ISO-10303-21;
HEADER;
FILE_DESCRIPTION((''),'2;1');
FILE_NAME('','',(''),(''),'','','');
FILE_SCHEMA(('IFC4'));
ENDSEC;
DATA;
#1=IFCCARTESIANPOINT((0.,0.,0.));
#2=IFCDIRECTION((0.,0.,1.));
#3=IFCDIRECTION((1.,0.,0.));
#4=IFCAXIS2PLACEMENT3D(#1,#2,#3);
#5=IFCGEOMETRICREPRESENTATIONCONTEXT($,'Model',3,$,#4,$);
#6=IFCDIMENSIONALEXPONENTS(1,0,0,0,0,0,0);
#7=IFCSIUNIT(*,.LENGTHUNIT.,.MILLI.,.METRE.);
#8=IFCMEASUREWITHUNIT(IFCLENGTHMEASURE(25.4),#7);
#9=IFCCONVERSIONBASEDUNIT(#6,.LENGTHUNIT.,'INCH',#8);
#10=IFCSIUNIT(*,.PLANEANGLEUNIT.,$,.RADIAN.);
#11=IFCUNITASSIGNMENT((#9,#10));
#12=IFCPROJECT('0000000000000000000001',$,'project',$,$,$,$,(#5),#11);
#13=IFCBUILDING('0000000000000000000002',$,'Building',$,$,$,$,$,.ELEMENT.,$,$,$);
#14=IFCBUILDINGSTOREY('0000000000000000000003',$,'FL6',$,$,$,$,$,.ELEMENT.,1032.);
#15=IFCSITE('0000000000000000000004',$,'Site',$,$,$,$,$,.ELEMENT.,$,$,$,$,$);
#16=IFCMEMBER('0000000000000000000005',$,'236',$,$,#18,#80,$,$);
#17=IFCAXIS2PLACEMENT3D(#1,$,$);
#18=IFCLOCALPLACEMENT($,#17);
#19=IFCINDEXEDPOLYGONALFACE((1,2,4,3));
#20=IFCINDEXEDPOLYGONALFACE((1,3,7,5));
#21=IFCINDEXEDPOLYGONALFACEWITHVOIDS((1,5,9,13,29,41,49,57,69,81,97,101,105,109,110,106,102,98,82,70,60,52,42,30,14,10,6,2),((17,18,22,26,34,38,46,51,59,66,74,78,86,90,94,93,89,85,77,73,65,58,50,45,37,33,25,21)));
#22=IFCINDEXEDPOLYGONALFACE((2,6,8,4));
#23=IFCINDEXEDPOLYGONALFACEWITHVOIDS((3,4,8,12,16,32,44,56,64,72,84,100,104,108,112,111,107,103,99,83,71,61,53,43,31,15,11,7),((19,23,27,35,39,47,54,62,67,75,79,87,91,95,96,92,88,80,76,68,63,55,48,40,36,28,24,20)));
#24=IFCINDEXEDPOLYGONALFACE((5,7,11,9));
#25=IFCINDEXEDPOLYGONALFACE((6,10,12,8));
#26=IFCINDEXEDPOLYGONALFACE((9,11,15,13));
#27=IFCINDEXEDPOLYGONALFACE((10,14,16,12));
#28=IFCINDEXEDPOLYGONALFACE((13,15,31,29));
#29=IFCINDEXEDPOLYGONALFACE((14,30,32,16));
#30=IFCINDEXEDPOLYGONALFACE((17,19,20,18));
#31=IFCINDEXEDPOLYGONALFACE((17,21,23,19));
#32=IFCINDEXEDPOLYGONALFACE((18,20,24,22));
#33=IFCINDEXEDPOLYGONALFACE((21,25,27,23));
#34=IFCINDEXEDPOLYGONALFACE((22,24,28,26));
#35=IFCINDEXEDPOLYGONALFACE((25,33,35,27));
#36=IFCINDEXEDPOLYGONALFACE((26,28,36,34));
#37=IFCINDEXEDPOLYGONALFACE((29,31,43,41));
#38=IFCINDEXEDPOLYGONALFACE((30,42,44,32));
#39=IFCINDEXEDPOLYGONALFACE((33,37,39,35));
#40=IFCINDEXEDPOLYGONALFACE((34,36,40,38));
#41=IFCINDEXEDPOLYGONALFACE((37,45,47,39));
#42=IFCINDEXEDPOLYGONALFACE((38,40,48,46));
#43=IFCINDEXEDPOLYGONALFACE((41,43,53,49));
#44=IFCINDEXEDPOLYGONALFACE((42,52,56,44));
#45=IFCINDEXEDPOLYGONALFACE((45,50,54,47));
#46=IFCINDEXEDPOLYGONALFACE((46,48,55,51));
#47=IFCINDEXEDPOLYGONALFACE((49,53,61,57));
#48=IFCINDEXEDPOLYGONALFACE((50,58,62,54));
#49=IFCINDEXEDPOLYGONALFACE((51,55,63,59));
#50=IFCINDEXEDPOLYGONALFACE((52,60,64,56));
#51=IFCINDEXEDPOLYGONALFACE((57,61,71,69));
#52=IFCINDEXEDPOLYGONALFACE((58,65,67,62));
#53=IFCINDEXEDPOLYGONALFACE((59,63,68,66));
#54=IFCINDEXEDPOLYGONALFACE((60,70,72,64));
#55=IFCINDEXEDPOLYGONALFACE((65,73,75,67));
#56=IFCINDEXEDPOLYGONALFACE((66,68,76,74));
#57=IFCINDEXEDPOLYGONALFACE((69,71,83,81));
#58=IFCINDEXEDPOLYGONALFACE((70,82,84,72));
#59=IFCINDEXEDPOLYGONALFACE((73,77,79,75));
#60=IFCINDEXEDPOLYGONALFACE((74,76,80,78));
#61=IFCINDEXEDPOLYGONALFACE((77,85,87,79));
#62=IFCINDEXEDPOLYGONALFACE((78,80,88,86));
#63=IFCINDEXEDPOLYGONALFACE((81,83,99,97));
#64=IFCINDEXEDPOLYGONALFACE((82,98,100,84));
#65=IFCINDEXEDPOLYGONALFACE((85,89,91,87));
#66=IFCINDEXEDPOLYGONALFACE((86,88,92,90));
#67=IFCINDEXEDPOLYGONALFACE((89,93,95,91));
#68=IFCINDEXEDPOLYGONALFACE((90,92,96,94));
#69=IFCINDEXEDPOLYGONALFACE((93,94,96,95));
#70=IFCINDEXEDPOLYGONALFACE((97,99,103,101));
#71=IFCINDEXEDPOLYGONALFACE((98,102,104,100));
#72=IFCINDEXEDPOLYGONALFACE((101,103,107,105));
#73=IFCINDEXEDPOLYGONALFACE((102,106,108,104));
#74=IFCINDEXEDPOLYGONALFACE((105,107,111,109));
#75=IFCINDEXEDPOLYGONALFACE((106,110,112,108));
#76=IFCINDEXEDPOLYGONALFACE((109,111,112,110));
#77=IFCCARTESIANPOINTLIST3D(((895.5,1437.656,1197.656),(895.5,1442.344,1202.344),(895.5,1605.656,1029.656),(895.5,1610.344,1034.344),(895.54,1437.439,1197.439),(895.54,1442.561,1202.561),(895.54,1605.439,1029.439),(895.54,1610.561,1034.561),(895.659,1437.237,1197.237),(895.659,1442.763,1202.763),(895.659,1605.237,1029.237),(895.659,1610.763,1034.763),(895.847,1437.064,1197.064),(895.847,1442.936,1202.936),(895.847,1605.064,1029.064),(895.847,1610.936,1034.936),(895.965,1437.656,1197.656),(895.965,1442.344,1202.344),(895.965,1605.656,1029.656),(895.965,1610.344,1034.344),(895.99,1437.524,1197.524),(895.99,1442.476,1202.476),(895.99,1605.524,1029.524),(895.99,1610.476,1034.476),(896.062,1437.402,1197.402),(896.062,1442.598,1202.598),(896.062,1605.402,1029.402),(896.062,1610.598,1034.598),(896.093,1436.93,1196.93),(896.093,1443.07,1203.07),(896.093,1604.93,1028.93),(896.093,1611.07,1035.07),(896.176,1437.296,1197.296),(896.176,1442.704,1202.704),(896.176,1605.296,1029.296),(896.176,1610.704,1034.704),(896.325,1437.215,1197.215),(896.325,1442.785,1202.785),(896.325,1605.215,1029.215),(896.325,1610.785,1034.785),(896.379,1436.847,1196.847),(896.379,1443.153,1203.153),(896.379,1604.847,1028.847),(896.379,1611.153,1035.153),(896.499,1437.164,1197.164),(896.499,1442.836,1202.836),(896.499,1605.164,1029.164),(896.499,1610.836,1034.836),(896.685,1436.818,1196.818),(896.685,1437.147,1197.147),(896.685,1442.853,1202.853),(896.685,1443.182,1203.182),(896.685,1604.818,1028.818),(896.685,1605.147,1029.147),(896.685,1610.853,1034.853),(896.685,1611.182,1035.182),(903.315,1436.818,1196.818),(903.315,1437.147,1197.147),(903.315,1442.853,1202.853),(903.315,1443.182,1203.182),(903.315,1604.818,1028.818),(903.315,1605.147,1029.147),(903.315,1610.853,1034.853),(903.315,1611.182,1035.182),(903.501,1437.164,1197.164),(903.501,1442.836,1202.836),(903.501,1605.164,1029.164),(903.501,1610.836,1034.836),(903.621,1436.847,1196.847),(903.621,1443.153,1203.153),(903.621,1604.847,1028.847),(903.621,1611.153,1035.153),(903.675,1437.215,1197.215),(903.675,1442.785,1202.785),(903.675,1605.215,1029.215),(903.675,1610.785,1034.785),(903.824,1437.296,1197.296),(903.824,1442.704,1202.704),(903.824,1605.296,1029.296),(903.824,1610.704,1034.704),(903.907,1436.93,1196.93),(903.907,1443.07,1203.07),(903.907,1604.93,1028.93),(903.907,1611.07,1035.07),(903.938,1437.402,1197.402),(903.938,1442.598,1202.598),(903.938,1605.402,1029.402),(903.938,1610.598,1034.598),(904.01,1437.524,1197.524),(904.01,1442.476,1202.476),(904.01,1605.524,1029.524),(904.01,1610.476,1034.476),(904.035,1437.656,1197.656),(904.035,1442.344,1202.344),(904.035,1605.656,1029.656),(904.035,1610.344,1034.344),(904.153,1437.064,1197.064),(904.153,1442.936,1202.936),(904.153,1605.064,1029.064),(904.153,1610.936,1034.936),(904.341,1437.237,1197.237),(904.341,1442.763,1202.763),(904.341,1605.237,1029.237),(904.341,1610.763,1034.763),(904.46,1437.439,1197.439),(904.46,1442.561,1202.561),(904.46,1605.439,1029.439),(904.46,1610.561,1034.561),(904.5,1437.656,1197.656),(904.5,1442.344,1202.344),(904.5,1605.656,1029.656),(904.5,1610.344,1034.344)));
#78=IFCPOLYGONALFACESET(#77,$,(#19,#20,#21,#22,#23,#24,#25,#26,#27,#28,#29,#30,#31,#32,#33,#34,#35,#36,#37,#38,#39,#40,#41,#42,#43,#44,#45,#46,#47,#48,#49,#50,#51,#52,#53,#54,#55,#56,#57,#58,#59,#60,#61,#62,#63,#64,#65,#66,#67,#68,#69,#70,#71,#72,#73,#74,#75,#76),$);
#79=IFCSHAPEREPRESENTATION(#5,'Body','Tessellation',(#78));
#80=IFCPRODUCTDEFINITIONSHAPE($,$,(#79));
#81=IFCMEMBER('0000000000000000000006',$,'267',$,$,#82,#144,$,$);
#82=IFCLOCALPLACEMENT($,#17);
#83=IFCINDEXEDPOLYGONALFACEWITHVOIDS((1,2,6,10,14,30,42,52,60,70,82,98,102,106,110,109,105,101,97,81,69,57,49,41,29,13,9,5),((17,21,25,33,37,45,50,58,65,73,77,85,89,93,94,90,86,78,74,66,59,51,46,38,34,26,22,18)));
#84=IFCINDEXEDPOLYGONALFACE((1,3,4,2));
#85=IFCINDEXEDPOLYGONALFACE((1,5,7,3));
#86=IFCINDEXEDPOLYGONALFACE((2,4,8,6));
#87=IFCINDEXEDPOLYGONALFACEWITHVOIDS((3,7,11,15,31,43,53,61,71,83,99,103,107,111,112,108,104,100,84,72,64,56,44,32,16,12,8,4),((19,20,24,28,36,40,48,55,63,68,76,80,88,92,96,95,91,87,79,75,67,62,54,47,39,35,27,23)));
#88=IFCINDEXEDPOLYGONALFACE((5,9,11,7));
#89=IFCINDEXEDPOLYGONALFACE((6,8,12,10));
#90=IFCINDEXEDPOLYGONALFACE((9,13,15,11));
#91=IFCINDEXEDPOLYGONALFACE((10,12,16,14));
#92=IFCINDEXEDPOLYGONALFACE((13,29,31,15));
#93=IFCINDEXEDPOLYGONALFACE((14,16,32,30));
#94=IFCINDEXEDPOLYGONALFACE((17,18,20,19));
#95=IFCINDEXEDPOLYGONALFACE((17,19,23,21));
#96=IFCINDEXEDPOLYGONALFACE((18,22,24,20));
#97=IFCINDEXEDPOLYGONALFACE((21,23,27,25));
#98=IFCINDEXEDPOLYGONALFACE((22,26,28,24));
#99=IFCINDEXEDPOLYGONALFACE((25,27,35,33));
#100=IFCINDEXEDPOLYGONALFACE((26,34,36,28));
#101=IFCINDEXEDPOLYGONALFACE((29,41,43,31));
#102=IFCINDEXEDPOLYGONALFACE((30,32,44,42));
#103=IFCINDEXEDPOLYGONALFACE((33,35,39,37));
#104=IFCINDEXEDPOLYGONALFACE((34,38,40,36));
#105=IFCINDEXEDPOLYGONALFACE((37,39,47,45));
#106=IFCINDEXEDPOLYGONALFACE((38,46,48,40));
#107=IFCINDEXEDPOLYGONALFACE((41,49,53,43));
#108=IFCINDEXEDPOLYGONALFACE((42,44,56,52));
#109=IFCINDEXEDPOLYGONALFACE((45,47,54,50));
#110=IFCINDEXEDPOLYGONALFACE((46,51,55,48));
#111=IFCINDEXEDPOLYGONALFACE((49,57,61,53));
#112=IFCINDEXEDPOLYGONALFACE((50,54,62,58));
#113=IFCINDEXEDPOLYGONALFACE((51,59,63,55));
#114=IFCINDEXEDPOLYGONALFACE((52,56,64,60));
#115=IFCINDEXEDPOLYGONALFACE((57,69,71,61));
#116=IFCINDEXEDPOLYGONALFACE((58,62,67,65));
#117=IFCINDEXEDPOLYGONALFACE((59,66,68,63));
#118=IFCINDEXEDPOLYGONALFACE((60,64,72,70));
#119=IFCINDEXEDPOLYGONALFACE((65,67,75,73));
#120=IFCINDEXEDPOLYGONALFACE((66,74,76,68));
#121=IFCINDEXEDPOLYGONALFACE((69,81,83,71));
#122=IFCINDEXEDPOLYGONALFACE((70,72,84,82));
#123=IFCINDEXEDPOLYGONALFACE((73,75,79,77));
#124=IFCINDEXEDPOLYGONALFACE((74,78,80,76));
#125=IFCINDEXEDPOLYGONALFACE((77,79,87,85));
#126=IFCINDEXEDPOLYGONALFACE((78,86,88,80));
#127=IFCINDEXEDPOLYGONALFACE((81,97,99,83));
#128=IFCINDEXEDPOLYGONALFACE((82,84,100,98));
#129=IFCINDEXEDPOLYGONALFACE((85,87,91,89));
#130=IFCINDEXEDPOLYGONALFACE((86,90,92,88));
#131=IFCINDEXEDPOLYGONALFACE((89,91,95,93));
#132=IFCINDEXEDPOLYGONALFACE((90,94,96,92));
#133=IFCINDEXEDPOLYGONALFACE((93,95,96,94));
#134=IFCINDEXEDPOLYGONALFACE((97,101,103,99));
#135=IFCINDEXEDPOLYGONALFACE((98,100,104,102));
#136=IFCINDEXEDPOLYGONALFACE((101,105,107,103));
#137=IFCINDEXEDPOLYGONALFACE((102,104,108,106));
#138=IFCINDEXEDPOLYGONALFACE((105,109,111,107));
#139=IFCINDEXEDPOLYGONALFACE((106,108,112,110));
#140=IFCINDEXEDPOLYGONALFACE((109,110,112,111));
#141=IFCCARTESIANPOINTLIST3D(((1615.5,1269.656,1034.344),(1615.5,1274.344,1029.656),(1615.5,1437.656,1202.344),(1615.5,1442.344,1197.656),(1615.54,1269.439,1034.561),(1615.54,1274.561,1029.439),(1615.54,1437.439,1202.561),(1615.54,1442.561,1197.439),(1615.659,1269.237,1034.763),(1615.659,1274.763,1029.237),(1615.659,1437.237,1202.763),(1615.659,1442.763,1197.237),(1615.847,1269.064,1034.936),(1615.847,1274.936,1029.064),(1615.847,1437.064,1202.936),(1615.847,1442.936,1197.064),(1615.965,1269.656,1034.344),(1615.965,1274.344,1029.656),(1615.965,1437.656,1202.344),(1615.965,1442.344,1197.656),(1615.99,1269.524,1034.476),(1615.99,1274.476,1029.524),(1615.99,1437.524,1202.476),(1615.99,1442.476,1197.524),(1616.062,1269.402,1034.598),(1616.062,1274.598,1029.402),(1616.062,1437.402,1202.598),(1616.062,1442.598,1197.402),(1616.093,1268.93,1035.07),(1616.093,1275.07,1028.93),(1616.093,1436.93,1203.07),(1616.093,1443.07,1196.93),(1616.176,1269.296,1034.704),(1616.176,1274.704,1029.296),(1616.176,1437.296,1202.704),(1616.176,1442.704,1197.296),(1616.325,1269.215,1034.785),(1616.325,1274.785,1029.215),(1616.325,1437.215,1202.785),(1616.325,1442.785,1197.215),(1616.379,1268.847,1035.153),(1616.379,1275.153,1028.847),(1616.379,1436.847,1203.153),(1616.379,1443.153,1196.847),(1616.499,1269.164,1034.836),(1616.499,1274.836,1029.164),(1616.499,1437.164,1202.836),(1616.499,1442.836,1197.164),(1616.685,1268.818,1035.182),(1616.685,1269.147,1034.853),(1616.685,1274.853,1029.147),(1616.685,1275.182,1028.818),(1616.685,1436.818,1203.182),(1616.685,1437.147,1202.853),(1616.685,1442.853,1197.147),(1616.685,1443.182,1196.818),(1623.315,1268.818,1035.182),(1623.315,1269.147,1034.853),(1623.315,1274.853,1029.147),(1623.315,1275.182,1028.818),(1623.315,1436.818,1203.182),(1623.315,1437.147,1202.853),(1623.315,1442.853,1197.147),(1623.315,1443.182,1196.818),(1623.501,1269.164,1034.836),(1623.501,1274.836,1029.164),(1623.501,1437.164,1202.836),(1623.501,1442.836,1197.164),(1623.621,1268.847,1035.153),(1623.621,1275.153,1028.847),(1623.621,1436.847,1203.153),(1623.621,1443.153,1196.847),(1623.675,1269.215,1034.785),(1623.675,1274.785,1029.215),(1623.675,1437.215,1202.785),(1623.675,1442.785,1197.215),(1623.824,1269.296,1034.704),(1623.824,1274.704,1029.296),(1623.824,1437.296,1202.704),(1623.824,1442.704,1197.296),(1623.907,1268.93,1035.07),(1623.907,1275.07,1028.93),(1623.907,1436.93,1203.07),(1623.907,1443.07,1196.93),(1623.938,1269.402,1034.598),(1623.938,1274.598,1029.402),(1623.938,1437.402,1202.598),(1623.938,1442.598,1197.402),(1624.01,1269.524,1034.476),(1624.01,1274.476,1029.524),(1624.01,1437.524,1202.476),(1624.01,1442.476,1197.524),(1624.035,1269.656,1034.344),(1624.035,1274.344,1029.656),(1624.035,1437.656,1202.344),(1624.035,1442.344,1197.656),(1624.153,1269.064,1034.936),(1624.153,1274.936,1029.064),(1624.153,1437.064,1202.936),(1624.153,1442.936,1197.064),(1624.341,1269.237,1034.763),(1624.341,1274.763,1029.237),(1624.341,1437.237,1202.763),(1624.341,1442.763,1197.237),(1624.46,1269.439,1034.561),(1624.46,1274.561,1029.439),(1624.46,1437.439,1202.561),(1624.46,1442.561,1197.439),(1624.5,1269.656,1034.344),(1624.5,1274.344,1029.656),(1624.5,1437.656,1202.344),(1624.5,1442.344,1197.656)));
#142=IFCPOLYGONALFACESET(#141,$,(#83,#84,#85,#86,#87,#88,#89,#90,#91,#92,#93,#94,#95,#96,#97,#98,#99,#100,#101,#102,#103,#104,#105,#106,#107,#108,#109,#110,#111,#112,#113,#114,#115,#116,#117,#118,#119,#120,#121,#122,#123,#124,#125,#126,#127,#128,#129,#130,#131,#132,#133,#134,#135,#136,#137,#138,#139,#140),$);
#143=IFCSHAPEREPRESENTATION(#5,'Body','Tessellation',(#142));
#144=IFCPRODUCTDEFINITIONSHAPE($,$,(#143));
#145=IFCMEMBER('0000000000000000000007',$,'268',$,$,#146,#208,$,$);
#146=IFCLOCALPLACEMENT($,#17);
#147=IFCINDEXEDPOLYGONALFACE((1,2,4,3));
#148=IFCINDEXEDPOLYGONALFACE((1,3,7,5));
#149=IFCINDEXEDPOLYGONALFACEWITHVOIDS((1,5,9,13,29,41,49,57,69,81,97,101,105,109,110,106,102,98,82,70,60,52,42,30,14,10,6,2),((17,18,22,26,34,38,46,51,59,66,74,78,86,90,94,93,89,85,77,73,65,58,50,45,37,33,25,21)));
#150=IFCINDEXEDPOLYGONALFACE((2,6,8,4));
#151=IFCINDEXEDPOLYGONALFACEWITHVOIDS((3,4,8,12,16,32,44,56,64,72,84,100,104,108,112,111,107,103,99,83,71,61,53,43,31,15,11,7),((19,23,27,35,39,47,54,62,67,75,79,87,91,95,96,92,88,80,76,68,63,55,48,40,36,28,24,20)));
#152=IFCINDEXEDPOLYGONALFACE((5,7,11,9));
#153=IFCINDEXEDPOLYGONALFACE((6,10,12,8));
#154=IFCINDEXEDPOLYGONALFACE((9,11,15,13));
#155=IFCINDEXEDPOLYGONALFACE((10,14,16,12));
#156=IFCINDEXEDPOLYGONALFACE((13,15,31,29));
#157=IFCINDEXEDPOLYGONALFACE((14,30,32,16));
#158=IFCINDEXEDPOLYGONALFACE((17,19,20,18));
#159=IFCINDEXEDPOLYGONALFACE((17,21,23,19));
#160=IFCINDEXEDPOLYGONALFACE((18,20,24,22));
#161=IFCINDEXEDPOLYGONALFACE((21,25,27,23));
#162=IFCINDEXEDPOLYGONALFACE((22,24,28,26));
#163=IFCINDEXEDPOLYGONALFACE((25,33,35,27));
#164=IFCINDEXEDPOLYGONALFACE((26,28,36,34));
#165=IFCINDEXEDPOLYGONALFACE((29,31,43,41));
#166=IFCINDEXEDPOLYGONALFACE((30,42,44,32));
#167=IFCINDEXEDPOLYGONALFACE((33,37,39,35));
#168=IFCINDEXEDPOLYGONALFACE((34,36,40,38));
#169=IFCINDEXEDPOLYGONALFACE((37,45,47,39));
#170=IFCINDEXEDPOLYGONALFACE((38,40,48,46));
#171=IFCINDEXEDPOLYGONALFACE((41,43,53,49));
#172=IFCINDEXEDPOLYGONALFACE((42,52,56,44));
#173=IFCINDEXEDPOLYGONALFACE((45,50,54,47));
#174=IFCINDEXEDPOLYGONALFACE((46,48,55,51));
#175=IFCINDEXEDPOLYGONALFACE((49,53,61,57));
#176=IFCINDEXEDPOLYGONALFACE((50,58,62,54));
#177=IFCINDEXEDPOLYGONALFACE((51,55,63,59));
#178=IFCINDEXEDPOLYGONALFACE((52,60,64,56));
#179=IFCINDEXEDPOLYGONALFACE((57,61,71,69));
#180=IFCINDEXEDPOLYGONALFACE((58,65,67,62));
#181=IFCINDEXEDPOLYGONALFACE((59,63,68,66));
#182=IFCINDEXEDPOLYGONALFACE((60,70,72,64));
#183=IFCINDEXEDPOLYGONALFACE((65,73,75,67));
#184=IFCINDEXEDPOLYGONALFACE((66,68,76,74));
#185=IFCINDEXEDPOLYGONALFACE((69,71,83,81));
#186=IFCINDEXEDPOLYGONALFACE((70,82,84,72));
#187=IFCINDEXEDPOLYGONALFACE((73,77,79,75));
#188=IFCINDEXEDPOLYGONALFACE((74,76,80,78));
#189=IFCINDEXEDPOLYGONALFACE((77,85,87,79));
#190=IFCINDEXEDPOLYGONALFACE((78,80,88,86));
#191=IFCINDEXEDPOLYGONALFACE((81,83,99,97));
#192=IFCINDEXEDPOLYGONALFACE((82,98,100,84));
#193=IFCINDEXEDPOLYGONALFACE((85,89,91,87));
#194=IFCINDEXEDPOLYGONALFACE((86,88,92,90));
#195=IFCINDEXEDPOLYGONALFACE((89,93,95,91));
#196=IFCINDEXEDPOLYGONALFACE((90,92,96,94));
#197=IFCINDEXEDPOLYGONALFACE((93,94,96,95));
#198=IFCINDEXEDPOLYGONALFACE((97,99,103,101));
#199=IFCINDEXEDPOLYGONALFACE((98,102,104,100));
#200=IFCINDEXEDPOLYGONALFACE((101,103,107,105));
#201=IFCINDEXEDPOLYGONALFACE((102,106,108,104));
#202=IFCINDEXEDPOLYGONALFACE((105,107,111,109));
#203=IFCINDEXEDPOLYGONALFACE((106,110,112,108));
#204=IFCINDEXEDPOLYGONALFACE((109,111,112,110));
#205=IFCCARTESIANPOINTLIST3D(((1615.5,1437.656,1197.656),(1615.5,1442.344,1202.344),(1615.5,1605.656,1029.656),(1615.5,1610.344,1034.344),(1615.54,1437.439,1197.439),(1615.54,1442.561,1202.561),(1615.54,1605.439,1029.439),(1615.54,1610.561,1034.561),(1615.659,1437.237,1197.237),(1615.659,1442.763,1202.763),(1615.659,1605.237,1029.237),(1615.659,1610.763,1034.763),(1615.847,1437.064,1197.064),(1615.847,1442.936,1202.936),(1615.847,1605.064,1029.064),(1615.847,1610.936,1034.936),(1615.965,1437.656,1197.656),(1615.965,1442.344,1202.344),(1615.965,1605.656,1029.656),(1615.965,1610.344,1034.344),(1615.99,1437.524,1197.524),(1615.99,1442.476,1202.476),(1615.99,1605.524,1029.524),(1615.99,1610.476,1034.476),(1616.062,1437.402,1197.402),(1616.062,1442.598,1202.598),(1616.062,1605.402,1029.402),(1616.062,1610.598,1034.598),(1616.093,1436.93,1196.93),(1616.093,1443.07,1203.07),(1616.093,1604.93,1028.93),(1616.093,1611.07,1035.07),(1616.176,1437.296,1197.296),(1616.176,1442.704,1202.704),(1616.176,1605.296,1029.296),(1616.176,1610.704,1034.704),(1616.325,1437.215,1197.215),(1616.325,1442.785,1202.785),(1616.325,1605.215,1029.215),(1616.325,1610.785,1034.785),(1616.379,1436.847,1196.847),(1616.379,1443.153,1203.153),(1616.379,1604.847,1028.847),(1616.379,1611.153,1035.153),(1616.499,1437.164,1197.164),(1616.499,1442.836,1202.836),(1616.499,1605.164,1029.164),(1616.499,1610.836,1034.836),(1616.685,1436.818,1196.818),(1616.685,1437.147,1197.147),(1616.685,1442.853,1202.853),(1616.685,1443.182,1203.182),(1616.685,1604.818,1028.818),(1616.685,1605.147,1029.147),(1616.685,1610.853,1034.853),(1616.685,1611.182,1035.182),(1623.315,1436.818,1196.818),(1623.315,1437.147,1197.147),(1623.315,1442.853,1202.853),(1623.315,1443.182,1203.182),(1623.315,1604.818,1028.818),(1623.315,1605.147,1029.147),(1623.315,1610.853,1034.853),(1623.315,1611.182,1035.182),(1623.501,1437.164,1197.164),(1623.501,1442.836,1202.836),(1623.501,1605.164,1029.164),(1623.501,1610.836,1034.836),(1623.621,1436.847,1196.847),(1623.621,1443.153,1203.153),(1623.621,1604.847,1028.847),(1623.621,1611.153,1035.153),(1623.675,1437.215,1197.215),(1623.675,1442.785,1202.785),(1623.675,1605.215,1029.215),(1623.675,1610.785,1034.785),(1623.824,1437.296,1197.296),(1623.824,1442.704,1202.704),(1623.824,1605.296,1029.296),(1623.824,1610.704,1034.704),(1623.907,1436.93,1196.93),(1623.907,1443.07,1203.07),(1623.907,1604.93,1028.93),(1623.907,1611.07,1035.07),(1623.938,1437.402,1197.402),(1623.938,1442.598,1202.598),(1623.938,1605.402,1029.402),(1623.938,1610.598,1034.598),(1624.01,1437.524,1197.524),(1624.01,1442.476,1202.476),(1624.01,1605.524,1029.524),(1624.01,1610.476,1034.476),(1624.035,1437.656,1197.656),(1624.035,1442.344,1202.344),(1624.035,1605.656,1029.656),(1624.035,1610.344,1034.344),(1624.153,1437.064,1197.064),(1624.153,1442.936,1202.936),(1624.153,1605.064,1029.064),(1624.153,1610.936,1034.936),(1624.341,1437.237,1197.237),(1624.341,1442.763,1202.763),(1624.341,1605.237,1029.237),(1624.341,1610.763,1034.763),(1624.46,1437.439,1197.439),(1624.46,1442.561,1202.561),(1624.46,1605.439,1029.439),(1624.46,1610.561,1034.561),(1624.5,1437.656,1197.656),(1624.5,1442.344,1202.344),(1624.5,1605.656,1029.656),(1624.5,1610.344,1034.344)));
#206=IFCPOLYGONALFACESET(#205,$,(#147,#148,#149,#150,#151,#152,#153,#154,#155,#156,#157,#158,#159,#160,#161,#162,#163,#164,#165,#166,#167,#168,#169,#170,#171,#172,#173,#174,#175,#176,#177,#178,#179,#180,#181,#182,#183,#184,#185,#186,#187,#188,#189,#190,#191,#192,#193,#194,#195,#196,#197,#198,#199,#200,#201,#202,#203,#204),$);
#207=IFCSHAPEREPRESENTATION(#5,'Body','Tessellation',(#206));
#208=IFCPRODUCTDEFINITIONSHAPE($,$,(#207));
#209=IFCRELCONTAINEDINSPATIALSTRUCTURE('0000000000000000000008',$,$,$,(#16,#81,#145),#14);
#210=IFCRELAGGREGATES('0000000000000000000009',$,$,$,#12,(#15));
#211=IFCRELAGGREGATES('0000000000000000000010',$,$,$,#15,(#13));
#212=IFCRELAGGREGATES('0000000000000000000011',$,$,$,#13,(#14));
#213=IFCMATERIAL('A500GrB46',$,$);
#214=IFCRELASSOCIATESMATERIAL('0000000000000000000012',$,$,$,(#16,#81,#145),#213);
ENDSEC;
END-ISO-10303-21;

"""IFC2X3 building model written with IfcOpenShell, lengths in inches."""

from ifc_helpers import new_model, entity, si_unit, converted_unit, frame, origin_with_axes, origin_2d_with_axis, place, context, project, spatial, hollow_rectangle, extrude, material, element, save


model = new_model("IFC2X3")

# Units and contexts
model_context = context("Model", 3, world=origin_with_axes())
ifc_project = project(units=[converted_unit("LENGTHUNIT", "INCH", entity("IfcLengthMeasure", 25.4), si_unit("LENGTHUNIT", "METRE", prefix="MILLI"), dimensions=[1, 0, 0, 0, 0, 0, 0]), si_unit("PLANEANGLEUNIT", "RADIAN")], contexts=[model_context])

# Site, building, storey
site = spatial("IfcSite", under=ifc_project, Name="Site", CompositionType="ELEMENT")
building = spatial("IfcBuilding", under=site, Name="Building", CompositionType="ELEMENT")
storey = spatial("IfcBuildingStorey", under=building, Name="FL6", CompositionType="ELEMENT", Elevation=1032.0)

# Members
ifc_material_1 = material(Name="A500GrB46")
for number, where, z_axis, x_axis, name in (
    (1, (900.0, 1608.0, 1032.0), (0.0, -0.707107, 0.707107), (1.0, 0.0, 0.0), "236"),
    (2, (1620.0, 1272.0, 1032.0), (0.0, 0.707107, 0.707107), (-1.0, 0.0, 0.0), "267"),
    (3, (1620.0, 1608.0, 1032.0), (0.0, -0.707107, 0.707107), (1.0, 0.0, 0.0), "268"),
):
    element("IfcMember", number, at=place(None, frame(where, z_axis=z_axis, x_axis=x_axis)), inside=storey, material=ifc_material_1, Name=name, context=model_context, shape_type="SweptSolid", body=[
        extrude(hollow_rectangle(XDim=9.0, YDim=9.0, WallThickness=0.465, InnerFilletRadius=0.72, OuterFilletRadius=1.185, at=origin_2d_with_axis()), origin_with_axes(), (0.0, 0.0, 1.0), 237.588),
    ])

save(model, "model.ifc")
